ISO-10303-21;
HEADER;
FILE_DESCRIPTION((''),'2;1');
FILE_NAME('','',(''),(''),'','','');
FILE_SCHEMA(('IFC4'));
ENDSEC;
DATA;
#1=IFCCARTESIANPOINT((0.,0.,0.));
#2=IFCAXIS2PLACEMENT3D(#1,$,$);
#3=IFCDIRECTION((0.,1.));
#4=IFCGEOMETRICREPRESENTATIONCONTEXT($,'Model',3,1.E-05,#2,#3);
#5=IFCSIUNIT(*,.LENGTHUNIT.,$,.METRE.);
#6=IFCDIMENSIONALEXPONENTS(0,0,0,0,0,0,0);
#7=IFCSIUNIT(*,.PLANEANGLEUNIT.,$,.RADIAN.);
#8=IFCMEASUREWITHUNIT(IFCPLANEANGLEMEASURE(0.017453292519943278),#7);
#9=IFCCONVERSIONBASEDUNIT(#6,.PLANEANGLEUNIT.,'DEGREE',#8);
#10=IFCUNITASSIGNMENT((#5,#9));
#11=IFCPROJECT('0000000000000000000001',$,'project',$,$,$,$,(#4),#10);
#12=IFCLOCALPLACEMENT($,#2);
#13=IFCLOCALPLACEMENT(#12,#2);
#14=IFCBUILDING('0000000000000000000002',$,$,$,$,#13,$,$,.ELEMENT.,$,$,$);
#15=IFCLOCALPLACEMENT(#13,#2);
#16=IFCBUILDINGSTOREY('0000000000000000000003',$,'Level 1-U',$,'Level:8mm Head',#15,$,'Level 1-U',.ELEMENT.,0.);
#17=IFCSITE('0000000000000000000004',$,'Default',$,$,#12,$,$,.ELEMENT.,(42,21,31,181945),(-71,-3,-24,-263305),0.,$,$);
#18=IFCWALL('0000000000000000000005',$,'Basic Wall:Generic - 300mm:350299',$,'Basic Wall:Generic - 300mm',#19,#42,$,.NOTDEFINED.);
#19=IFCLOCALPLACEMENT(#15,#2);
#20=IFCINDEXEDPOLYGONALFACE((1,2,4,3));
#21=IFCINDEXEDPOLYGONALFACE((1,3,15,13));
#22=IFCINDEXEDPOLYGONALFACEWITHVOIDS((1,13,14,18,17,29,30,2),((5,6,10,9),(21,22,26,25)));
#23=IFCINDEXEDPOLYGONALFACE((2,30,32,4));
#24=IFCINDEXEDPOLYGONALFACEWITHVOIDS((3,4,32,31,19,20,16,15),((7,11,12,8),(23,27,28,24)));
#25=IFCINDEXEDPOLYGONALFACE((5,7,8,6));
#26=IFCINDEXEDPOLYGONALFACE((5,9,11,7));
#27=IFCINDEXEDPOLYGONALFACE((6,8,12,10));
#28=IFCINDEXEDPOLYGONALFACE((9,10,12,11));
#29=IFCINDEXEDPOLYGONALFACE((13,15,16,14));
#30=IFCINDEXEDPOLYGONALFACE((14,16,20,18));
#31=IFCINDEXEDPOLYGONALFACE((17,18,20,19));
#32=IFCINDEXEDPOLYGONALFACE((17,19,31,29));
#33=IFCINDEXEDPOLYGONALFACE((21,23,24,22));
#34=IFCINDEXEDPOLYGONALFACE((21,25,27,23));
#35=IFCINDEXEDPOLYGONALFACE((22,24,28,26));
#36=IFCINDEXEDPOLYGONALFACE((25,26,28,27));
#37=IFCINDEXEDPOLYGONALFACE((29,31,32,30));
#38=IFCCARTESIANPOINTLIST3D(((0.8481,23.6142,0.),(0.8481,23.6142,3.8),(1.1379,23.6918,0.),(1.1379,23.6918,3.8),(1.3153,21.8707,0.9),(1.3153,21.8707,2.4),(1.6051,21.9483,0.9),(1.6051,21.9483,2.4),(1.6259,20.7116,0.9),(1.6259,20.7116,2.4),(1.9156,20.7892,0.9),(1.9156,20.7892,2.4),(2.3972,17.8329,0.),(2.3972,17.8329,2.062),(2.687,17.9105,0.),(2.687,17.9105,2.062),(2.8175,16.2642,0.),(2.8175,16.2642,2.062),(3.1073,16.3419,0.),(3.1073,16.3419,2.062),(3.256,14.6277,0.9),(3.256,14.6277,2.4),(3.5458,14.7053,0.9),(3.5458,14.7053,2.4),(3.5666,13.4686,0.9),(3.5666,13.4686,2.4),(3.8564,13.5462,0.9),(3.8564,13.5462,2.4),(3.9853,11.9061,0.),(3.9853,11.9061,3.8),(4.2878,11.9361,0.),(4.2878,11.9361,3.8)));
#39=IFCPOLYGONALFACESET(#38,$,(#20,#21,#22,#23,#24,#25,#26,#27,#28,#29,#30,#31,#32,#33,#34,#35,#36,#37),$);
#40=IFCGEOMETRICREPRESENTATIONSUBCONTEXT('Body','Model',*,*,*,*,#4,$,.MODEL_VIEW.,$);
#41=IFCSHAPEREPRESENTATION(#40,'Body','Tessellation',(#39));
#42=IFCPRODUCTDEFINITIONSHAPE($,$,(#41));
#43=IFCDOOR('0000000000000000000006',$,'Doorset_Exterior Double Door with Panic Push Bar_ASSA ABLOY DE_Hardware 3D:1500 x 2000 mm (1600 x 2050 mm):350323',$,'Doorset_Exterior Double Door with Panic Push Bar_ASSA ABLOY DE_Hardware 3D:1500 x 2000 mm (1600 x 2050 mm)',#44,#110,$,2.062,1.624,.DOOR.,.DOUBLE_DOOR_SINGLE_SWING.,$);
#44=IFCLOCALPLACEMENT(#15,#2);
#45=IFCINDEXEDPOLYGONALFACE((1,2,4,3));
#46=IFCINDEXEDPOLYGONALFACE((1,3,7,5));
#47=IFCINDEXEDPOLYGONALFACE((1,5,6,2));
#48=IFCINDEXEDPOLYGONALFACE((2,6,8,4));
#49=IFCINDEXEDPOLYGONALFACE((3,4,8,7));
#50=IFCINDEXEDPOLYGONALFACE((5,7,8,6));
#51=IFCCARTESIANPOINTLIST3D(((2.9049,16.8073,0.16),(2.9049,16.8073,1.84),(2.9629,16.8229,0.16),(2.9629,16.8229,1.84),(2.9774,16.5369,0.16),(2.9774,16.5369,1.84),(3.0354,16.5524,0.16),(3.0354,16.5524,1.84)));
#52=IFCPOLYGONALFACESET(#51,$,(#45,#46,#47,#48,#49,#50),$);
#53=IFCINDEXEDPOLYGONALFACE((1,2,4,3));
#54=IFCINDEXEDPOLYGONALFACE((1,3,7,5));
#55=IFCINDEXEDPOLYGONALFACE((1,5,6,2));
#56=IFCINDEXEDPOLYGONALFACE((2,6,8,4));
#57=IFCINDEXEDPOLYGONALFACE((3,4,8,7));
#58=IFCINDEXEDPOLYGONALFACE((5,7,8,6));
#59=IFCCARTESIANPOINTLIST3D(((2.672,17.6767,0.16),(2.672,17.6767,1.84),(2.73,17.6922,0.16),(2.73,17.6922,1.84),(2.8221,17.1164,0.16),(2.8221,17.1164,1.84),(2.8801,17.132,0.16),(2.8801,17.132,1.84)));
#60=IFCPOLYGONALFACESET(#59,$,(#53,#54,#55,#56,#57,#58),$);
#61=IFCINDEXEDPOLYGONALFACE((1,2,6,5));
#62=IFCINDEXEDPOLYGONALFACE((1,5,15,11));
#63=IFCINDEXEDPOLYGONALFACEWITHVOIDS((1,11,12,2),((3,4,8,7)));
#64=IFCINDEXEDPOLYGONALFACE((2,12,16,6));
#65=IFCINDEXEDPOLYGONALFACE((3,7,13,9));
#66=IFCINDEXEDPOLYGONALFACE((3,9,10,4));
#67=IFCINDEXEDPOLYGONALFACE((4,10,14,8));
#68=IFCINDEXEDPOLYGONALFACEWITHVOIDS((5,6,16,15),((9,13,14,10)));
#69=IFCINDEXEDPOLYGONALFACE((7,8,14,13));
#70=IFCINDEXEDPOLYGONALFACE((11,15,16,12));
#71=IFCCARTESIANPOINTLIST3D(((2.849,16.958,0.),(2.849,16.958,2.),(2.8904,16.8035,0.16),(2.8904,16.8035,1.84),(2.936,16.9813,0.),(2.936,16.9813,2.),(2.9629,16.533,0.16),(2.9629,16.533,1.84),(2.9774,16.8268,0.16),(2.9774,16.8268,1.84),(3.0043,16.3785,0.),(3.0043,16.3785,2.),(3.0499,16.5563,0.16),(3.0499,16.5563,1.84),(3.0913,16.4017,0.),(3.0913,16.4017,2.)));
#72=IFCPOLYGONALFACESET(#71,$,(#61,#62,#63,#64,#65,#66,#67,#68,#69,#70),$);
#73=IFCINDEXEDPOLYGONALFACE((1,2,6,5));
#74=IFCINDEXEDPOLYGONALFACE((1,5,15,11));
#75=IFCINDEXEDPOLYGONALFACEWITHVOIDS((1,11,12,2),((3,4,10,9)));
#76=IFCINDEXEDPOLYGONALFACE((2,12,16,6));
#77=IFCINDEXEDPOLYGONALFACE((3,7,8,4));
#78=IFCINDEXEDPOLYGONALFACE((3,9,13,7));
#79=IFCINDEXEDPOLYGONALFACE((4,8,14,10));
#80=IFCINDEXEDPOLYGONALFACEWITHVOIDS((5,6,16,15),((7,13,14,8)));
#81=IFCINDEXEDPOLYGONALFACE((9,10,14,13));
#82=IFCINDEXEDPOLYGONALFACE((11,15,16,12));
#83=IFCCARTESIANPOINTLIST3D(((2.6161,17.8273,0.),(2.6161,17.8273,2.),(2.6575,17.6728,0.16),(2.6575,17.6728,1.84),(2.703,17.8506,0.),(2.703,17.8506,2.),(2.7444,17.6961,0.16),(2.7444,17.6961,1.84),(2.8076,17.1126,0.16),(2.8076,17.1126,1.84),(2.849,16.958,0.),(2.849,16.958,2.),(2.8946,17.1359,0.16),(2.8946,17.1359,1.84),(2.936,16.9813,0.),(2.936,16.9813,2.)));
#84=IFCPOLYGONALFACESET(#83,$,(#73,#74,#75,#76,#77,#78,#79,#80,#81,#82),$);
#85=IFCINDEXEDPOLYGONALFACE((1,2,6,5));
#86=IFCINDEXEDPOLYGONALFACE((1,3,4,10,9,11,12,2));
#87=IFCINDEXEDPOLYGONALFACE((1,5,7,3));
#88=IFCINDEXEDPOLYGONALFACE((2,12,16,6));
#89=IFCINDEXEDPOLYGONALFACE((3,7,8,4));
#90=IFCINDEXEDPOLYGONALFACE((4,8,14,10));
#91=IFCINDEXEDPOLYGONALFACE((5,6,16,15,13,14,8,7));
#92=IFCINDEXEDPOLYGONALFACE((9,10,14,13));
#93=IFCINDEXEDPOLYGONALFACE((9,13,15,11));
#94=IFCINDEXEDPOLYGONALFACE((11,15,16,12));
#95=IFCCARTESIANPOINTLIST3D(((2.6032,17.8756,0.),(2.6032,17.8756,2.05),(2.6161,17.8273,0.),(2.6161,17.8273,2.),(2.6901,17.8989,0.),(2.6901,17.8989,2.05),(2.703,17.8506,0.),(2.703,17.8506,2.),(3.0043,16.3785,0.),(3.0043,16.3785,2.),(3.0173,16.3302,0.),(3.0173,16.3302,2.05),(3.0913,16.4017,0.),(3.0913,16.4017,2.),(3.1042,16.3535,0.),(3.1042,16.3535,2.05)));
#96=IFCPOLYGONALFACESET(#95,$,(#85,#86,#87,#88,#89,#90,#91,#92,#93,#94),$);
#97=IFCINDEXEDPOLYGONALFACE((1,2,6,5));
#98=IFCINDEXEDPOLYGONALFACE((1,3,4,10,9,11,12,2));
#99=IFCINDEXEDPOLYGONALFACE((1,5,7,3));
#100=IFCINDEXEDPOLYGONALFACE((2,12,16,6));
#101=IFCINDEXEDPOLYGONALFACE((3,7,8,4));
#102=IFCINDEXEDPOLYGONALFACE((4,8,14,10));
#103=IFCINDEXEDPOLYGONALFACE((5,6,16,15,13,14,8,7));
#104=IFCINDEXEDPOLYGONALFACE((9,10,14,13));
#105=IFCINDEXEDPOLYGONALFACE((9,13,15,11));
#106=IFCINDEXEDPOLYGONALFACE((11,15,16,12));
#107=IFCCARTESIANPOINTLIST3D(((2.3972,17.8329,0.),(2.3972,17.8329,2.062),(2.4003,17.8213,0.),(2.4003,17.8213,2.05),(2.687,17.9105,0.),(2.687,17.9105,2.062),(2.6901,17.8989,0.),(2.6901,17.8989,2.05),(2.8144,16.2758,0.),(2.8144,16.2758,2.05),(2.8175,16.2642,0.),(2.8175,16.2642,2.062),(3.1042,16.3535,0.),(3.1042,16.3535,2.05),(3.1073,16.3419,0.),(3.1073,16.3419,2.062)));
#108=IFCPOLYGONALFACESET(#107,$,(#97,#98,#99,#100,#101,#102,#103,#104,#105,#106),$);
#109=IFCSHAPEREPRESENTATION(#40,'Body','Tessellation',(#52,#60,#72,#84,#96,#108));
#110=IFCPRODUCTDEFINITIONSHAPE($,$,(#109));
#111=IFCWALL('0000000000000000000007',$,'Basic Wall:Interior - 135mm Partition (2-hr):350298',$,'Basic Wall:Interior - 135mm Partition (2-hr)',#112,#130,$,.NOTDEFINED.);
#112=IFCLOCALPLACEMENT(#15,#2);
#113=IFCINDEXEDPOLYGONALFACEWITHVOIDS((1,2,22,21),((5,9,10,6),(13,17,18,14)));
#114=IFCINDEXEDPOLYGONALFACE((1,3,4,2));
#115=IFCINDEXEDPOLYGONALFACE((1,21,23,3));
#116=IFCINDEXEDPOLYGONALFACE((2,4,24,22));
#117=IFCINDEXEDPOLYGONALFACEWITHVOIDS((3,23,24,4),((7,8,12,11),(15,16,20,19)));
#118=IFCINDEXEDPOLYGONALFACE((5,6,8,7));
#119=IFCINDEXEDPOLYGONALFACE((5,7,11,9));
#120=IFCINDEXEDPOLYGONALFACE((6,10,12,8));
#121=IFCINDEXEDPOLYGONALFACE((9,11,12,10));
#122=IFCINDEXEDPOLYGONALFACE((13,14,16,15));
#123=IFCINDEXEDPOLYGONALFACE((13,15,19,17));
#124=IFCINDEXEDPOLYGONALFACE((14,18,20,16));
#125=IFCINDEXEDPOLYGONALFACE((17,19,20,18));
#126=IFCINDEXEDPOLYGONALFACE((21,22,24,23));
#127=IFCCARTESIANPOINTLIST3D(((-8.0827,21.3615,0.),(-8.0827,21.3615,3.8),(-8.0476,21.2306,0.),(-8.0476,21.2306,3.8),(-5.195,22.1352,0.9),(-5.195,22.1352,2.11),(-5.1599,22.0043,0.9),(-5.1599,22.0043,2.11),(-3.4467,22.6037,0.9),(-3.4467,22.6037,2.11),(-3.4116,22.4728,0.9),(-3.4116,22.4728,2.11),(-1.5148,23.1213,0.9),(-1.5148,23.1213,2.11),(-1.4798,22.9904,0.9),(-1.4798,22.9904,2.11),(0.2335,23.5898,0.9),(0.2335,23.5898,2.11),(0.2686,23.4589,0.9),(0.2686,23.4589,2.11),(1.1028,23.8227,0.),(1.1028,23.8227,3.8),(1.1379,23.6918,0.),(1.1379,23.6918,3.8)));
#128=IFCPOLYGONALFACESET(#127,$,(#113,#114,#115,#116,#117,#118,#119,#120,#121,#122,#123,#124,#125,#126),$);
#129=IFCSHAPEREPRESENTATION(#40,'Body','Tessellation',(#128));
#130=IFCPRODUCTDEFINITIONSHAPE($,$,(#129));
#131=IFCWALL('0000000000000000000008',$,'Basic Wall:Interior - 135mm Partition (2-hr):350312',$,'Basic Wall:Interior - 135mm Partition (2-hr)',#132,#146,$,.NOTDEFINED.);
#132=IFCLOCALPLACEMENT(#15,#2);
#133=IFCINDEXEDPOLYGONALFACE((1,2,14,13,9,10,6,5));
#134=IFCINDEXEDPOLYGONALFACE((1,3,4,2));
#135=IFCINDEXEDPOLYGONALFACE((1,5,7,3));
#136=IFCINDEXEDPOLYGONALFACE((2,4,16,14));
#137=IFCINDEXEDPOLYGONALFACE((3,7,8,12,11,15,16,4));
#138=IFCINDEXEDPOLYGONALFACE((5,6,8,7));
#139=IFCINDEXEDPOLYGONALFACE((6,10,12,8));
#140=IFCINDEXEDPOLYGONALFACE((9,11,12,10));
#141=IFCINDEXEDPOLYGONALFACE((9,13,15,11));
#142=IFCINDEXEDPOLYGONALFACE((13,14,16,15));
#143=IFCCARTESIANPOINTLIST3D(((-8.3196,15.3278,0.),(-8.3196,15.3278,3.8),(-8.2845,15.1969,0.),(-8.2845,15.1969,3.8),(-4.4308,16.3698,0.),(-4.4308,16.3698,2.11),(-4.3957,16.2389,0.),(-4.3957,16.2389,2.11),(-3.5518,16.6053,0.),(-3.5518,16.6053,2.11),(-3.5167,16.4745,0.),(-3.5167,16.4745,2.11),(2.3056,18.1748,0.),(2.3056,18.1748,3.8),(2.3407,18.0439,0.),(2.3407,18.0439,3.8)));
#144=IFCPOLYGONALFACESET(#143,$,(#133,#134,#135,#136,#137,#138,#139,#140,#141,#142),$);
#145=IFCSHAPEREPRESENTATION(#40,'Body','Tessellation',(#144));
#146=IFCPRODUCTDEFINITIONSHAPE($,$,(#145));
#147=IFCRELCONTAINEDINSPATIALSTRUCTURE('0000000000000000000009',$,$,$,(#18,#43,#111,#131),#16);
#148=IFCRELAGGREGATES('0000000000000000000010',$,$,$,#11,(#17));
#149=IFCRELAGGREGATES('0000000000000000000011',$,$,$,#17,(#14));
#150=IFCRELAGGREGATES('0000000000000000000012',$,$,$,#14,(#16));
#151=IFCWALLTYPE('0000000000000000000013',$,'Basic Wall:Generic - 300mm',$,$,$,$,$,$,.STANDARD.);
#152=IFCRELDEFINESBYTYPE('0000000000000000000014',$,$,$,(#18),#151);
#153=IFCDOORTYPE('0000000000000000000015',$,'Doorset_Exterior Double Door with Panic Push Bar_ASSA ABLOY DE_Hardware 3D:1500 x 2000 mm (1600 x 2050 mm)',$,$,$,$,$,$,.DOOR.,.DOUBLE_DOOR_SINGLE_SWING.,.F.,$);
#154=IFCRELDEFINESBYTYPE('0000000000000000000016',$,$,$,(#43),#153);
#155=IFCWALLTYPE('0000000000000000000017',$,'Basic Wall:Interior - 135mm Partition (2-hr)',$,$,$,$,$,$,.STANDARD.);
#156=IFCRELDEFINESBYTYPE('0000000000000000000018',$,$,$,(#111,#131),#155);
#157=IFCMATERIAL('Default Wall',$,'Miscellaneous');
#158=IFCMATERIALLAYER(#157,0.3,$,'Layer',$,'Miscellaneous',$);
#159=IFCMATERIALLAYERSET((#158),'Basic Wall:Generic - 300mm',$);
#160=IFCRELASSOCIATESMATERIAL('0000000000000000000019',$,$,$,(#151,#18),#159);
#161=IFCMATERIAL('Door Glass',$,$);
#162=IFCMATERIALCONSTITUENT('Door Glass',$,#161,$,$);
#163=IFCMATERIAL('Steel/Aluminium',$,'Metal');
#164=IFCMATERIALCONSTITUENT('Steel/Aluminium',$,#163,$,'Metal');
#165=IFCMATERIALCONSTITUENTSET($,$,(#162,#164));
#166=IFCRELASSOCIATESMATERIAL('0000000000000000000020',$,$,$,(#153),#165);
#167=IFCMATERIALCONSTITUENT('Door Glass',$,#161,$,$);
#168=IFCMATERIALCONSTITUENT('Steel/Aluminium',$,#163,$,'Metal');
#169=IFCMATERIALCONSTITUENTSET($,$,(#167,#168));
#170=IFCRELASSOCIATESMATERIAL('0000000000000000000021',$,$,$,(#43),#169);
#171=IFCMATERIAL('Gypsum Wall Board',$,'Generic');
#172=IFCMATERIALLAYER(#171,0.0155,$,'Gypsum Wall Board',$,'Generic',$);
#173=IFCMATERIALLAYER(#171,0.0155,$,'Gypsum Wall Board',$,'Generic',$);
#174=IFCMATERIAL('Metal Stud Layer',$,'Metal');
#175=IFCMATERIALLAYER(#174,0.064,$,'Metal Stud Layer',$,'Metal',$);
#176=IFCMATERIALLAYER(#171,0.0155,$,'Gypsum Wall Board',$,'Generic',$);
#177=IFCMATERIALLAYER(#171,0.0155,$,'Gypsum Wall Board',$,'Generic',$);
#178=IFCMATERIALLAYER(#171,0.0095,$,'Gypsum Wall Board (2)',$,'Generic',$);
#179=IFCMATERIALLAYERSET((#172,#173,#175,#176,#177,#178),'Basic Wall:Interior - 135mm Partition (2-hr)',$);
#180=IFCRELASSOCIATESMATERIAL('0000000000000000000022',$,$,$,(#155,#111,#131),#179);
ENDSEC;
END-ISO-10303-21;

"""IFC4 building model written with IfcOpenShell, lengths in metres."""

from ifc_helpers import new_model, entity, si_unit, converted_unit, direction, frame, frame_2d, origin, place, context, subcontext, project, spatial, polyline, rectangle, outline, extrude, source, transform, mapped, material, layer, layer_set, layer_usage, constituent, constituent_set, type_object, type_shapes, element, fill, save


model = new_model("IFC4")

# Units and contexts
model_context = context("Model", 3, precision=1e-05, world=origin(), true_north=direction((0.0, 1.0)))
body_context = subcontext(model_context, "Body", "Model", "MODEL_VIEW")
ifc_project = project(units=[si_unit("LENGTHUNIT", "METRE"), converted_unit("PLANEANGLEUNIT", "DEGREE", entity("IfcPlaneAngleMeasure", 0.017453292519943278), si_unit("PLANEANGLEUNIT", "RADIAN"), dimensions=[0, 0, 0, 0, 0, 0, 0])], contexts=[model_context])

# Site, building, storey
site_placement = place(None, origin())
site = spatial("IfcSite", under=ifc_project, at=site_placement, Name="Default", CompositionType="ELEMENT", RefLatitude=(42, 21, 31, 181945), RefLongitude=(-71, -3, -24, -263305), RefElevation=0.0)
building_placement = place(site_placement, origin())
building = spatial("IfcBuilding", under=site, at=building_placement, CompositionType="ELEMENT")
storey_placement = place(building_placement, origin())
storey = spatial("IfcBuildingStorey", under=building, at=storey_placement, Name="Level 1-U", ObjectType="Level:8mm Head", LongName="Level 1-U", CompositionType="ELEMENT", Elevation=0.0)

# Wall, openings, door
ifc_material_1 = material(Name="Default Wall", Category="Miscellaneous")
ifc_layer_1 = layer(ifc_material_1, 0.3, Name="Layer", Category="Miscellaneous")
ifc_layer_set_1 = layer_set([ifc_layer_1], Name="Basic Wall:Generic - 300mm")
ifc_layer_usage_1 = layer_usage(ifc_layer_set_1, "AXIS2", "POSITIVE", -0.15)
wall_type_1 = type_object("IfcWallType", Name="Basic Wall:Generic - 300mm", PredefinedType="STANDARD", material=ifc_layer_set_1)
wall_1_placement = place(storey_placement, frame((0.993, 23.653, 0.0), z_axis=(0.0, 0.0, 1.0), x_axis=(0.258819, -0.965926, 0.0)))
wall_1 = element("IfcWall", 1, at=wall_1_placement, inside=storey, type_object=wall_type_1, material=ifc_layer_usage_1, Name="Basic Wall:Generic - 300mm:350299", ObjectType="Basic Wall:Generic - 300mm", PredefinedType="NOTDEFINED", context=body_context, shape_type="SweptSolid", body=[
    extrude(outline(polyline([(0.0, -0.15), (12.1211, -0.15), (12.1704, 0.15), (0.0, 0.15), (0.0, -0.15)])), origin(), (0.0, 0.0, 1.0), 3.8),
])
opening_1_placement = place(wall_1_placement, frame((5.9853, -0.15, 0.0)))
opening_1 = element("IfcOpeningElement", 2, at=opening_1_placement, cuts=wall_1, PredefinedType="OPENING", context=body_context, shape_type="SweptSolid", body=[
    extrude(rectangle(XDim=2.062, YDim=1.624, at=frame_2d((1.031, 0.812), x_axis=(-1.0, 0.0))), frame((0.0, 0.0, 0.0), z_axis=(0.0, 1.0, 0.0), x_axis=(0.0, 0.0, 1.0)), (0.0, 0.0, 1.0), 0.3),
])
opening_2_placement = place(wall_1_placement, frame((1.805, -0.15, 0.9)))
element("IfcOpeningElement", 3, at=opening_2_placement, cuts=wall_1, PredefinedType="OPENING", context=body_context, shape_type="SweptSolid", body=[
    extrude(rectangle(XDim=1.5, YDim=1.2, at=frame_2d((0.75, 0.6), x_axis=(-1.0, 0.0))), frame((0.0, 0.0, 0.0), z_axis=(0.0, 1.0, 0.0), x_axis=(0.0, 0.0, 1.0)), (0.0, 0.0, 1.0), 0.3),
])
opening_3_placement = place(wall_1_placement, frame((9.3035, -0.15, 0.9)))
element("IfcOpeningElement", 4, at=opening_3_placement, cuts=wall_1, PredefinedType="OPENING", context=body_context, shape_type="SweptSolid", body=[
    extrude(rectangle(XDim=1.5, YDim=1.2, at=frame_2d((0.75, 0.6), x_axis=(-1.0, 0.0))), frame((0.0, 0.0, 0.0), z_axis=(0.0, 1.0, 0.0), x_axis=(0.0, 0.0, 1.0)), (0.0, 0.0, 1.0), 0.3),
])
ifc_material_2 = material(Name="Door Glass")
ifc_constituent_1 = constituent(ifc_material_2, Name="Door Glass")
ifc_material_3 = material(Name="Steel/Aluminium", Category="Metal")
ifc_constituent_2 = constituent(ifc_material_3, Name="Steel/Aluminium", Category="Metal")
ifc_constituent_set_1 = constituent_set(constituents=[ifc_constituent_1, ifc_constituent_2])
ifc_constituent_3 = constituent(ifc_material_2, Name="Door Glass")
ifc_constituent_4 = constituent(ifc_material_3, Name="Steel/Aluminium", Category="Metal")
ifc_constituent_set_2 = constituent_set(constituents=[ifc_constituent_3, ifc_constituent_4])
door_type = type_object("IfcDoorType", Name="Doorset_Exterior Double Door with Panic Push Bar_ASSA ABLOY DE_Hardware 3D:1500 x 2000 mm (1600 x 2050 mm)", OperationType="DOUBLE_DOOR_SINGLE_SWING", ParameterTakesPrecedence=False, PredefinedType="DOOR", material=ifc_constituent_set_2)
shared_shape_1 = source(origin(), body_context, "Body", "SweptSolid", [
    extrude(rectangle(XDim=0.28, YDim=0.06, at=frame_2d((0.0, 0.0), x_axis=(1.0, 0.0))), frame((1.262, 0.255, 0.16)), (0.0, 0.0, 1.0), 1.68),
    extrude(rectangle(XDim=0.58, YDim=0.06, at=frame_2d((0.0, 0.0), x_axis=(1.0, 0.0))), frame((0.512, 0.255, 0.16)), (0.0, 0.0, 1.0), 1.68),
    extrude(outline(polyline([(-0.3, -1.0), (0.3, -1.0), (0.3, 1.0), (-0.3, 1.0), (-0.3, -1.0)]), holes=[polyline([(0.14, -0.84), (-0.14, -0.84), (-0.14, 0.84), (0.14, 0.84), (0.14, -0.84)])]), frame((1.262, 0.3, 1.0), z_axis=(0.0, -1.0, 0.0), x_axis=(1.0, 0.0, 0.0)), (0.0, 0.0, 1.0), 0.09),
    extrude(outline(polyline([(-1.0, -0.45), (1.0, -0.45), (1.0, 0.45), (-1.0, 0.45), (-1.0, -0.45)]), holes=[polyline([(-0.84, -0.29), (-0.84, 0.29), (0.84, 0.29), (0.84, -0.29), (-0.84, -0.29)])]), frame((0.512, 0.3, 1.0), z_axis=(0.0, -1.0, 0.0), x_axis=(0.0, 0.0, -1.0)), (0.0, 0.0, 1.0), 0.09),
    extrude(outline(polyline([(-1.0375, -0.8), (1.0125, -0.8), (1.0125, -0.75), (-0.9875, -0.75), (-0.9875, 0.75), (1.0125, 0.75), (1.0125, 0.8), (-1.0375, 0.8), (-1.0375, -0.8)])), frame((0.812, 0.3, 1.0125), z_axis=(0.0, -1.0, 0.0), x_axis=(0.0, 0.0, -1.0)), (0.0, 0.0, 1.0), 0.09),
    extrude(outline(polyline([(-0.812, -1.034), (0.812, -1.034), (0.812, 1.028), (0.8, 1.028), (0.8, -1.022), (-0.8, -1.022), (-0.8, 1.028), (-0.812, 1.028), (-0.812, -1.034)])), frame((0.812, 0.3, 1.028), z_axis=(0.0, -1.0, 0.0), x_axis=(-1.0, 0.0, 0.0)), (0.0, 0.0, 1.0), 0.3),
])
type_shapes(door_type, [shared_shape_1])
door_placement = place(opening_1_placement, origin())
door = element("IfcDoor", 5, at=door_placement, inside=storey, type_object=door_type, material=ifc_constituent_set_1, Name="Doorset_Exterior Double Door with Panic Push Bar_ASSA ABLOY DE_Hardware 3D:1500 x 2000 mm (1600 x 2050 mm):350323", ObjectType="Doorset_Exterior Double Door with Panic Push Bar_ASSA ABLOY DE_Hardware 3D:1500 x 2000 mm (1600 x 2050 mm)", OperationType="DOUBLE_DOOR_SINGLE_SWING", OverallHeight=2.062, OverallWidth=1.624, PredefinedType="DOOR", context=body_context, shape_type="MappedRepresentation", body=[
    mapped(shared_shape_1, transform((0.0, 0.0, 0.0), scale=1.0)),
])
fill(opening_1, door)

# Wall, openings
ifc_material_4 = material(Name="Gypsum Wall Board", Category="Generic")
ifc_layer_2 = layer(ifc_material_4, 0.0155, Name="Gypsum Wall Board", Category="Generic")
ifc_layer_3 = layer(ifc_material_4, 0.0155, Name="Gypsum Wall Board", Category="Generic")
ifc_material_5 = material(Name="Metal Stud Layer", Category="Metal")
ifc_layer_4 = layer(ifc_material_5, 0.064, Name="Metal Stud Layer", Category="Metal")
ifc_layer_5 = layer(ifc_material_4, 0.0155, Name="Gypsum Wall Board", Category="Generic")
ifc_layer_6 = layer(ifc_material_4, 0.0155, Name="Gypsum Wall Board", Category="Generic")
ifc_layer_7 = layer(ifc_material_4, 0.0095, Name="Gypsum Wall Board (2)", Category="Generic")
ifc_layer_set_2 = layer_set([ifc_layer_2, ifc_layer_3, ifc_layer_4, ifc_layer_5, ifc_layer_6, ifc_layer_7], Name="Basic Wall:Interior - 135mm Partition (2-hr)")
ifc_layer_usage_2 = layer_usage(ifc_layer_set_2, "AXIS2", "NEGATIVE", 0.0677)
wall_type_2 = type_object("IfcWallType", Name="Basic Wall:Interior - 135mm Partition (2-hr)", PredefinedType="STANDARD", material=ifc_layer_set_2)
wall_2_placement = place(storey_placement, frame((-8.0651, 21.296, 0.0), z_axis=(0.0, 0.0, 1.0), x_axis=(0.965926, 0.258819, 0.0)))
wall_2 = element("IfcWall", 6, at=wall_2_placement, inside=storey, type_object=wall_type_2, material=ifc_layer_usage_2, Name="Basic Wall:Interior - 135mm Partition (2-hr):350298", ObjectType="Basic Wall:Interior - 135mm Partition (2-hr)", PredefinedType="NOTDEFINED", context=body_context, shape_type="SweptSolid", body=[
    extrude(rectangle(XDim=9.5095, YDim=0.1355, at=frame_2d((4.7547, 0.0), x_axis=(-1.0, 0.0))), origin(), (0.0, 0.0, 1.0), 3.8),
])
opening_4_placement = place(wall_2_placement, frame((2.9895, -0.0678, 0.9)))
element("IfcOpeningElement", 7, at=opening_4_placement, cuts=wall_2, PredefinedType="OPENING", context=body_context, shape_type="SweptSolid", body=[
    extrude(rectangle(XDim=1.21, YDim=1.81, at=frame_2d((0.605, 0.905), x_axis=(-1.0, 0.0))), frame((0.0, 0.0, 0.0), z_axis=(0.0, 1.0, 0.0), x_axis=(0.0, 0.0, 1.0)), (0.0, 0.0, 1.0), 0.1355),
])
opening_5_placement = place(wall_2_placement, frame((8.6095, 0.0677, 0.9)))
element("IfcOpeningElement", 8, at=opening_5_placement, cuts=wall_2, PredefinedType="OPENING", context=body_context, shape_type="SweptSolid", body=[
    extrude(rectangle(XDim=1.21, YDim=1.81, at=frame_2d((0.605, 0.905), x_axis=(-1.0, 0.0))), frame((0.0, 0.0, 0.0), z_axis=(0.0, -1.0, 0.0), x_axis=(0.0, 0.0, 1.0)), (0.0, 0.0, 1.0), 0.1355),
])

# Wall, opening
wall_3_placement = place(storey_placement, frame((-8.3021, 15.2624, 0.0), z_axis=(0.0, 0.0, 1.0), x_axis=(0.965926, 0.258819, 0.0)))
wall_3 = element("IfcWall", 9, at=wall_3_placement, inside=storey, type_object=wall_type_2, material=ifc_layer_usage_2, Name="Basic Wall:Interior - 135mm Partition (2-hr):350312", ObjectType="Basic Wall:Interior - 135mm Partition (2-hr)", PredefinedType="NOTDEFINED", context=body_context, shape_type="SweptSolid", body=[
    extrude(rectangle(XDim=11.0, YDim=0.1355, at=frame_2d((5.5, 0.0), x_axis=(1.0, 0.0))), origin(), (0.0, 0.0, 1.0), 3.8),
])
opening_6_placement = place(wall_3_placement, frame((4.026, -0.0678, 0.0)))
element("IfcOpeningElement", 10, at=opening_6_placement, cuts=wall_3, PredefinedType="OPENING", context=body_context, shape_type="SweptSolid", body=[
    extrude(rectangle(XDim=2.11, YDim=0.91, at=frame_2d((1.055, 0.455), x_axis=(1.0, 0.0))), frame((0.0, 0.0, 0.0), z_axis=(0.0, 1.0, 0.0), x_axis=(0.0, 0.0, 1.0)), (0.0, 0.0, 1.0), 0.1355),
])

save(model, "model.ifc")
